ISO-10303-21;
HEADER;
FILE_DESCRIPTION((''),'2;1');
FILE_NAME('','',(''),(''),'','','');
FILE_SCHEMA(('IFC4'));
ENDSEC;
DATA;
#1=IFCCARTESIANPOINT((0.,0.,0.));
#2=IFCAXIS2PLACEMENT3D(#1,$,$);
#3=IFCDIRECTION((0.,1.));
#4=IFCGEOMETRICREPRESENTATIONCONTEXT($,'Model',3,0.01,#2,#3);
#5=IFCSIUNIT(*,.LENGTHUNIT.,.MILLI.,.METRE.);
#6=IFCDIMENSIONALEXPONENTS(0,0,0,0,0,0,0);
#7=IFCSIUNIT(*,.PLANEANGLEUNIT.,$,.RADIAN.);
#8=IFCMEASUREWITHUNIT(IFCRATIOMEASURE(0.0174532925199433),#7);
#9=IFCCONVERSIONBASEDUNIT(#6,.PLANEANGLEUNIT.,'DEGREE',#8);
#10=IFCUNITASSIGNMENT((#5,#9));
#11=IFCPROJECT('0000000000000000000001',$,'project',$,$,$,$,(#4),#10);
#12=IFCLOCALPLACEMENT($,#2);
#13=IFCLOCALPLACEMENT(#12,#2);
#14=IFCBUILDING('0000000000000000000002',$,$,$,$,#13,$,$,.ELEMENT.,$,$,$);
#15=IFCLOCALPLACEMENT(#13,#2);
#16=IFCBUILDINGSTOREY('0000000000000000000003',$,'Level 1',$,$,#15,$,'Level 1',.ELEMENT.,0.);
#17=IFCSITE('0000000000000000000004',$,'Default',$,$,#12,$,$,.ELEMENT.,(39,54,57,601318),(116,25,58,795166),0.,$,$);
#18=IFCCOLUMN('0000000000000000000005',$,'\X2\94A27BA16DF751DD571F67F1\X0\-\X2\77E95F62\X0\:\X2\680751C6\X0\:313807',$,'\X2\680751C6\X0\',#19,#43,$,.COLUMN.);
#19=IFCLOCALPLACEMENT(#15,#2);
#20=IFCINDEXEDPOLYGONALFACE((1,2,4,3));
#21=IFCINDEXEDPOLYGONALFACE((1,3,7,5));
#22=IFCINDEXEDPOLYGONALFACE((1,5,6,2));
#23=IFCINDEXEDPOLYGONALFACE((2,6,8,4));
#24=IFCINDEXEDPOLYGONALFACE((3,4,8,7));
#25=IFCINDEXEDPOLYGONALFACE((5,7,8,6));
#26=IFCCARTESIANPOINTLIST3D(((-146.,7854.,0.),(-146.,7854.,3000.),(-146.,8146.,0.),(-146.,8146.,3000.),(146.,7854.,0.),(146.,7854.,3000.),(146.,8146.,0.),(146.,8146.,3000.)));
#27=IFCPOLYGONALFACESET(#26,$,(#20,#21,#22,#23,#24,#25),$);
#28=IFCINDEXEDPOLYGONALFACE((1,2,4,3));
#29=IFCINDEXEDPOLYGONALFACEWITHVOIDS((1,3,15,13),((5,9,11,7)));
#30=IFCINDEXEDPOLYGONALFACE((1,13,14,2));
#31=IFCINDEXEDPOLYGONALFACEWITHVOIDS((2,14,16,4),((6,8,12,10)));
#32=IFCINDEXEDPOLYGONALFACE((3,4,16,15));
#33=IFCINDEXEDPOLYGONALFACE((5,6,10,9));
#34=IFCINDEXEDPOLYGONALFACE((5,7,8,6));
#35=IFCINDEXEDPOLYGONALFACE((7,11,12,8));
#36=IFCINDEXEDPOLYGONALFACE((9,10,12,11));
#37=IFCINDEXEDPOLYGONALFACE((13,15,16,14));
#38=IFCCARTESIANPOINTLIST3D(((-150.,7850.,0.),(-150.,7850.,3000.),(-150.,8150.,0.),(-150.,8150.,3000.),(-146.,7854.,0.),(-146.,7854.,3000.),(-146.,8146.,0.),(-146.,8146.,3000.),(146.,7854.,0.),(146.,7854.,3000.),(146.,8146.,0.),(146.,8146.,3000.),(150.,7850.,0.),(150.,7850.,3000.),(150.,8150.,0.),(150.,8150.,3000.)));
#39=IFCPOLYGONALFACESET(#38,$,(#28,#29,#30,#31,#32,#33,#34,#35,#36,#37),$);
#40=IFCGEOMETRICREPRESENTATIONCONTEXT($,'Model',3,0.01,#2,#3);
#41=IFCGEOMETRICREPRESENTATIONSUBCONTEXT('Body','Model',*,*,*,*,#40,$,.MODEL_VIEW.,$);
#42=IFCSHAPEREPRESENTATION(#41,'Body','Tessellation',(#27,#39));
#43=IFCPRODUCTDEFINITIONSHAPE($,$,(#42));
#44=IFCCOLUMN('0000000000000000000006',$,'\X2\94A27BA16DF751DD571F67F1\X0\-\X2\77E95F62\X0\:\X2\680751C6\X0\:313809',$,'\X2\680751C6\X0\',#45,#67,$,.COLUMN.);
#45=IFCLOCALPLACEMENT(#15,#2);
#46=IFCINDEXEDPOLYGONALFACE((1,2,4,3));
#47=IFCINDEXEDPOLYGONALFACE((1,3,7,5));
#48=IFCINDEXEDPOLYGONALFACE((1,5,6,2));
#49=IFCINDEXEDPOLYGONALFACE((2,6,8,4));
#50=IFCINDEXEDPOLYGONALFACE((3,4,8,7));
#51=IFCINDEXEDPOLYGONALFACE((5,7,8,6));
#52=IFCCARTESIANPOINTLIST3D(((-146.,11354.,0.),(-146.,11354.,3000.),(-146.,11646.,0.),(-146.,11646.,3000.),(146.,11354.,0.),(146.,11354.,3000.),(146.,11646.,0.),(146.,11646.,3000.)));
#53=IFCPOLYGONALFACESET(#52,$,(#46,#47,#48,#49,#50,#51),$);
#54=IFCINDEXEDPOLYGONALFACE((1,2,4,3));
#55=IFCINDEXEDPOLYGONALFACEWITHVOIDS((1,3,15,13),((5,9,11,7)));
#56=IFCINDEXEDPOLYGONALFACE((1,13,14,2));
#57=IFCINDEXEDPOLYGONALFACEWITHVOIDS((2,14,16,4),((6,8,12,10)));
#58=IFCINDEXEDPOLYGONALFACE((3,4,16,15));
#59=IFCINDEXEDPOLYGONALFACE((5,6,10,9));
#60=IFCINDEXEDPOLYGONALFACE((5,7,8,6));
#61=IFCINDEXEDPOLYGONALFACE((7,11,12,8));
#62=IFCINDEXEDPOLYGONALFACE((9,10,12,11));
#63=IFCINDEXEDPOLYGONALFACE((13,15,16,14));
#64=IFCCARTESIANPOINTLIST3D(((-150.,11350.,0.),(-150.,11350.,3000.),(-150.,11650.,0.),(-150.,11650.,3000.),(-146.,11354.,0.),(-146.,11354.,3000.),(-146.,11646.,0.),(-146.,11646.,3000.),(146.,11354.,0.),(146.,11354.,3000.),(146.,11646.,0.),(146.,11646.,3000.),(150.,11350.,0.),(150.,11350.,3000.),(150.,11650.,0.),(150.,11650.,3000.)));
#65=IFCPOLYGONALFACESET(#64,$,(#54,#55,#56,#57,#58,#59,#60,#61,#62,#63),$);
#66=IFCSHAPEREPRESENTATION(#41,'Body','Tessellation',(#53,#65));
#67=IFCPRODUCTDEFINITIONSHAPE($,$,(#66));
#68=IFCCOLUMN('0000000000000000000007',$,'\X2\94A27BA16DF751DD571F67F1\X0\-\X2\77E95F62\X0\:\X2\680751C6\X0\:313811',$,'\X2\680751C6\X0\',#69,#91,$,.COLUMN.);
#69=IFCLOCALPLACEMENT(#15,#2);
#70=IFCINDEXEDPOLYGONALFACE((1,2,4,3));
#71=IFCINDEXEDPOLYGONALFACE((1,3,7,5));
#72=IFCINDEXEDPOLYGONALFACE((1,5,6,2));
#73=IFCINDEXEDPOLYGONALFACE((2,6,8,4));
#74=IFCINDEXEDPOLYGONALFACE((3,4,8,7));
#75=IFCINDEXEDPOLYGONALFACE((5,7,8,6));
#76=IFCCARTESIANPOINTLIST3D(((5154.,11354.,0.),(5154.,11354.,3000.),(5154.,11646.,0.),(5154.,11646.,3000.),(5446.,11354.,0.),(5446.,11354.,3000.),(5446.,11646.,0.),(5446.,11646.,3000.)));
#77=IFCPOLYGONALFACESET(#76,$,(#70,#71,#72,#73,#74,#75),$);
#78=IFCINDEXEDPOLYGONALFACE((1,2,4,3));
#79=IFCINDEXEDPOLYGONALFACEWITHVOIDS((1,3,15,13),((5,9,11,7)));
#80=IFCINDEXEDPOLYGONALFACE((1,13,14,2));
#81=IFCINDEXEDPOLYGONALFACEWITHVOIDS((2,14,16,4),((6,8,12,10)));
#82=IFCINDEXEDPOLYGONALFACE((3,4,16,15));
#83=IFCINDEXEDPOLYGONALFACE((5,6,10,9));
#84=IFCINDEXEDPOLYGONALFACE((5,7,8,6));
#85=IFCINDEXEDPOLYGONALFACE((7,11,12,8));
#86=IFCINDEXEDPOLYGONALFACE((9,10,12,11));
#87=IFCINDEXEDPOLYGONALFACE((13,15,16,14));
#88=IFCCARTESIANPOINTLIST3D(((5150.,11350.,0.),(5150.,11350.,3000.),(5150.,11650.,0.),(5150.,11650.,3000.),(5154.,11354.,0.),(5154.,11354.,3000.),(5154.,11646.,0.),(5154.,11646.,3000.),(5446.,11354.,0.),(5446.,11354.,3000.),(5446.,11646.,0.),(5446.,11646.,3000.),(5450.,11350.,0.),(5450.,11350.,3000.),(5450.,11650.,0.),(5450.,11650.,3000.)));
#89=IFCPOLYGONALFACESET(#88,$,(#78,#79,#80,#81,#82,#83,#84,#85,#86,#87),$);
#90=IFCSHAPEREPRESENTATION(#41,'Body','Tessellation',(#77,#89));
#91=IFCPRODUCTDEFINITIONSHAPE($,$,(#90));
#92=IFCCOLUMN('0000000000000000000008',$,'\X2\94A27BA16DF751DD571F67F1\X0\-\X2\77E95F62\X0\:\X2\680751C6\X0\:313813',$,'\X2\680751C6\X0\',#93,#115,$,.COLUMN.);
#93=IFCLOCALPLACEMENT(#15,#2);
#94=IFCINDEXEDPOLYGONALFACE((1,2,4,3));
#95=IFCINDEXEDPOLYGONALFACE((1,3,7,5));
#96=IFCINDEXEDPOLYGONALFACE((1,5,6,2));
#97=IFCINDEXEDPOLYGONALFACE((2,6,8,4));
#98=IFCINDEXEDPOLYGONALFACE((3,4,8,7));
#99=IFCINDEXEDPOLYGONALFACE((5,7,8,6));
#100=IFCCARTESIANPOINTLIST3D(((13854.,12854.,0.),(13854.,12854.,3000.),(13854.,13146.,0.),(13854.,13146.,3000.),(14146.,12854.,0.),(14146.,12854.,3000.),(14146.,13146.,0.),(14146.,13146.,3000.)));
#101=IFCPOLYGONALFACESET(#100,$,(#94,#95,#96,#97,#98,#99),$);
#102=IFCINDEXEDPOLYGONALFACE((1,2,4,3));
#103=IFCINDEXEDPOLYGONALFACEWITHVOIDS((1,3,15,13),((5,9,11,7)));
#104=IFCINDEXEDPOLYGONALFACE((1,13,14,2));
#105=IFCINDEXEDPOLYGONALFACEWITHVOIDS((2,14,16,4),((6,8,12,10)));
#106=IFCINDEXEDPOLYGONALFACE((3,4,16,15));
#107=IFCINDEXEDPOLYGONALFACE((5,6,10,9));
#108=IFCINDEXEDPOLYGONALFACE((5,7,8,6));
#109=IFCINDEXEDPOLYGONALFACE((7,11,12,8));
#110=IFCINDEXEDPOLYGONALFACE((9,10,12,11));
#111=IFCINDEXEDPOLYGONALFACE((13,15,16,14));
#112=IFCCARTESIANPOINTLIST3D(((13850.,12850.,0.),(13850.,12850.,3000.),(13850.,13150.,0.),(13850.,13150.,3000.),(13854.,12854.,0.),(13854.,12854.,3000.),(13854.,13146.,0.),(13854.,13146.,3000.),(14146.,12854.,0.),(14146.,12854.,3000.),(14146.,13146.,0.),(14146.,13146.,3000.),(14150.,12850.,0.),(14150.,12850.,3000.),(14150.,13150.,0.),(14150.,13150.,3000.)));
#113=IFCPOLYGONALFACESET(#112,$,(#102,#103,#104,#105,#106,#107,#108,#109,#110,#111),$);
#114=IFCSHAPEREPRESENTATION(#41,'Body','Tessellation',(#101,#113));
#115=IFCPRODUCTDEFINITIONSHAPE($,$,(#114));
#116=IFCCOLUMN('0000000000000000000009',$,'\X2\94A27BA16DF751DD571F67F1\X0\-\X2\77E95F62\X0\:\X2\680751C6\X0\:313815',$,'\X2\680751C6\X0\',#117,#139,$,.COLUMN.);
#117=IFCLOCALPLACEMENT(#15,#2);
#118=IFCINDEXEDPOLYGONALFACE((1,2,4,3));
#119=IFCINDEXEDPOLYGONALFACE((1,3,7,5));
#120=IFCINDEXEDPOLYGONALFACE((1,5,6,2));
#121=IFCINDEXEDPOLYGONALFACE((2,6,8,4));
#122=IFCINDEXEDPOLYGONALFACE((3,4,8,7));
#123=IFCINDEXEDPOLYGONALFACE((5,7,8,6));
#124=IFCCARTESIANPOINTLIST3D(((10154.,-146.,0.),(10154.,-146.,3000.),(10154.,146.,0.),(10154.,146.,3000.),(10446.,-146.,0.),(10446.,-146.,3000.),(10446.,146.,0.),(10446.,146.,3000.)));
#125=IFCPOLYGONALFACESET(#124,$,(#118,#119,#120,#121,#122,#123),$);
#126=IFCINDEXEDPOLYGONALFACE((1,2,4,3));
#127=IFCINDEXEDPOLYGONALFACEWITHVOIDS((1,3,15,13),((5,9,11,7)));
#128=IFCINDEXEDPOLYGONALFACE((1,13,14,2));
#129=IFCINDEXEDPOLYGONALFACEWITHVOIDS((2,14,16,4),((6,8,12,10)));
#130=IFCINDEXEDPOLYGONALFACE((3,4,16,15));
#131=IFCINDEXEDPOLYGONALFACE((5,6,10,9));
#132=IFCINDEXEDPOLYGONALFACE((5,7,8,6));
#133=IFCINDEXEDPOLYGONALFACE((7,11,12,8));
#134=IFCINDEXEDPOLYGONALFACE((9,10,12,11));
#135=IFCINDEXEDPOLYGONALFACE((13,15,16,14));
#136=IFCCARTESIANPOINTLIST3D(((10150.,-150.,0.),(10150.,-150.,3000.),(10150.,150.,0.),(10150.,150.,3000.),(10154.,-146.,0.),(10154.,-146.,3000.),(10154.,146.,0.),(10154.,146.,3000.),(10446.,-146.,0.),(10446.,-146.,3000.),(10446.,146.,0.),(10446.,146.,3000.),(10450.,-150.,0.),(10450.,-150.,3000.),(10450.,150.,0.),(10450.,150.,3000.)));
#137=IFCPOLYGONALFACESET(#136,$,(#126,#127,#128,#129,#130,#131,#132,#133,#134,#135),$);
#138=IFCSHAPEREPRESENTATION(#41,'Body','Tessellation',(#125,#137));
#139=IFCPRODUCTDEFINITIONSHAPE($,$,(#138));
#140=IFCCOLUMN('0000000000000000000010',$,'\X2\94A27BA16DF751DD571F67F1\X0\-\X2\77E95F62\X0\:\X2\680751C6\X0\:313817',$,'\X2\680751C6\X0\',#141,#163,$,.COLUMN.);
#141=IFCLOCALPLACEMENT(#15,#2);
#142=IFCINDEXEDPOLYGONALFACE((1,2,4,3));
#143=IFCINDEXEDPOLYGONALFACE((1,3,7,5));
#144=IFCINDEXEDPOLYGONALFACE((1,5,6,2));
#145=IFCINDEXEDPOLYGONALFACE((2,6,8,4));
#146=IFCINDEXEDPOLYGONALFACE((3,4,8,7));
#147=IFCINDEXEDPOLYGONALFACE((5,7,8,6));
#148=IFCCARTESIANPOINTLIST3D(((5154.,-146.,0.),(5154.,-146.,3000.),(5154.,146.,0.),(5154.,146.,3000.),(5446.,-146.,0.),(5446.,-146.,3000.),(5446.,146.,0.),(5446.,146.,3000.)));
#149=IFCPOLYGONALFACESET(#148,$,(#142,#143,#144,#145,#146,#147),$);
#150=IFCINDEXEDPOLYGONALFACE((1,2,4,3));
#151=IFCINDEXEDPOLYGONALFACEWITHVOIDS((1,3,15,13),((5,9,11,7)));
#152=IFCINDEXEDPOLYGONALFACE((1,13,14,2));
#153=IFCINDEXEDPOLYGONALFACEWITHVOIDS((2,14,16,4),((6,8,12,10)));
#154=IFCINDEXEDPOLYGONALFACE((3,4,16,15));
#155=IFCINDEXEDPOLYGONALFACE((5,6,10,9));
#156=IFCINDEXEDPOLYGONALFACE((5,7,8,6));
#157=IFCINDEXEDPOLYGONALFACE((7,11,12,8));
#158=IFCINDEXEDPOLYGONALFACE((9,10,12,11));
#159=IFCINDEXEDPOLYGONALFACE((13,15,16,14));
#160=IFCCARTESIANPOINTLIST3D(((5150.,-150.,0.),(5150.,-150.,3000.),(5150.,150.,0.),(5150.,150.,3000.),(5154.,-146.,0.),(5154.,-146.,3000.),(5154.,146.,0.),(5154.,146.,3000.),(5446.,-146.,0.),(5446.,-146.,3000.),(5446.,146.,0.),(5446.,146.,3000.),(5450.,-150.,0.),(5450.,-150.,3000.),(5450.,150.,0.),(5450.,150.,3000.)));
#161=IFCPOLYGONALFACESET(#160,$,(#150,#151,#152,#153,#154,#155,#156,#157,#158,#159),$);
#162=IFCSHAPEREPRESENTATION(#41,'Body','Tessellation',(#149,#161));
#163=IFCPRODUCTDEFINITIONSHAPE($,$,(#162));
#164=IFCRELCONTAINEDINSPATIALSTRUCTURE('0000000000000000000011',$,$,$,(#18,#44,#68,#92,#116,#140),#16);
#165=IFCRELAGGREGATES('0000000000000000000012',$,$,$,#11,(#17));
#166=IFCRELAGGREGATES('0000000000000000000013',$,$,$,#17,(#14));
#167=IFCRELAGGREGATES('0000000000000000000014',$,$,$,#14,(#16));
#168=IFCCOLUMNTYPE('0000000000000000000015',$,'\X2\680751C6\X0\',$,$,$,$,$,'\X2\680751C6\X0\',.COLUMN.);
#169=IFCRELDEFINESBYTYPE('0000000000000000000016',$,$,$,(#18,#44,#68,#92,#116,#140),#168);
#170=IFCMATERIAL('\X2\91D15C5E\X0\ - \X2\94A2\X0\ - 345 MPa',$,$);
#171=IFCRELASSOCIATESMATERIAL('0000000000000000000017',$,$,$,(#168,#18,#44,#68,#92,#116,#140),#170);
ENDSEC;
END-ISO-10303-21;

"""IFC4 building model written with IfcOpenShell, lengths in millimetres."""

from ifc_helpers import new_model, entity, si_unit, converted_unit, direction, frame, origin, origin_2d_with_axis, place, context, subcontext, project, spatial, polyline, rectangle, outline, extrude, source, transform, mapped, material, type_object, type_shapes, element, save


model = new_model("IFC4")

# Units and contexts
model_context_1 = context("Model", 3, precision=0.01, world=origin(), true_north=direction((0.0, 1.0)))
model_context_2 = context("Model", 3, precision=0.01, world=origin(), true_north=direction((0.0, 1.0)))
body_context = subcontext(model_context_2, "Body", "Model", "MODEL_VIEW")
ifc_project = project(units=[si_unit("LENGTHUNIT", "METRE", prefix="MILLI"), converted_unit("PLANEANGLEUNIT", "DEGREE", entity("IfcRatioMeasure", 0.0174532925199433), si_unit("PLANEANGLEUNIT", "RADIAN"), dimensions=[0, 0, 0, 0, 0, 0, 0])], contexts=[model_context_1])

# Site, building, storey
site_placement = place(None, origin())
site = spatial("IfcSite", under=ifc_project, at=site_placement, Name="Default", CompositionType="ELEMENT", RefLatitude=(39, 54, 57, 601318), RefLongitude=(116, 25, 58, 795166), RefElevation=0.0)
building_placement = place(site_placement, origin())
building = spatial("IfcBuilding", under=site, at=building_placement, CompositionType="ELEMENT")
storey_placement = place(building_placement, origin())
storey = spatial("IfcBuildingStorey", under=building, at=storey_placement, Name="Level 1", LongName="Level 1", CompositionType="ELEMENT", Elevation=0.0)

# Columns
ifc_material = material(Name="金属 - 钢 - 345 MPa")
column_type = type_object("IfcColumnType", Name="标准", ElementType="标准", PredefinedType="COLUMN", material=ifc_material)
shared_shape = source(origin(), body_context, "Body", "SweptSolid", [
    extrude(rectangle(XDim=292.0, YDim=292.0, at=origin_2d_with_axis()), frame((0.0, 0.0, 0.0), z_axis=(0.0, 0.0, 1.0), x_axis=(-1.0, 0.0, 0.0)), (0.0, 0.0, 1.0), 3000.0),
    extrude(outline(polyline([(-150.0, -150.0), (150.0, -150.0), (150.0, 150.0), (-150.0, 150.0), (-150.0, -150.0)]), holes=[polyline([(-146.0, -146.0), (-146.0, 146.0), (146.0, 146.0), (146.0, -146.0), (-146.0, -146.0)])]), frame((0.0, 0.0, 0.0), z_axis=(0.0, 0.0, 1.0), x_axis=(-1.0, 0.0, 0.0)), (0.0, 0.0, 1.0), 3000.0),
])
type_shapes(column_type, [shared_shape])
for number, where, name in (
    (1, (0.0, 8000.0, 0.0), "钢管混凝土柱-矩形:标准:313807"),
    (2, (0.0, 11500.0, 0.0), "钢管混凝土柱-矩形:标准:313809"),
    (3, (5300.0, 11500.0, 0.0), "钢管混凝土柱-矩形:标准:313811"),
    (4, (14000.0, 13000.0, 0.0), "钢管混凝土柱-矩形:标准:313813"),
    (5, (10300.0, 0.0, 0.0), "钢管混凝土柱-矩形:标准:313815"),
    (6, (5300.0, 0.0, 0.0), "钢管混凝土柱-矩形:标准:313817"),
):
    element("IfcColumn", number, at=place(storey_placement, frame(where)), inside=storey, type_object=column_type, material=ifc_material, Name=name, ObjectType="标准", PredefinedType="COLUMN", context=body_context, shape_type="MappedRepresentation", body=[
        mapped(shared_shape, transform((0.0, 0.0, 0.0), scale=1.0)),
    ])

save(model, "model.ifc")
